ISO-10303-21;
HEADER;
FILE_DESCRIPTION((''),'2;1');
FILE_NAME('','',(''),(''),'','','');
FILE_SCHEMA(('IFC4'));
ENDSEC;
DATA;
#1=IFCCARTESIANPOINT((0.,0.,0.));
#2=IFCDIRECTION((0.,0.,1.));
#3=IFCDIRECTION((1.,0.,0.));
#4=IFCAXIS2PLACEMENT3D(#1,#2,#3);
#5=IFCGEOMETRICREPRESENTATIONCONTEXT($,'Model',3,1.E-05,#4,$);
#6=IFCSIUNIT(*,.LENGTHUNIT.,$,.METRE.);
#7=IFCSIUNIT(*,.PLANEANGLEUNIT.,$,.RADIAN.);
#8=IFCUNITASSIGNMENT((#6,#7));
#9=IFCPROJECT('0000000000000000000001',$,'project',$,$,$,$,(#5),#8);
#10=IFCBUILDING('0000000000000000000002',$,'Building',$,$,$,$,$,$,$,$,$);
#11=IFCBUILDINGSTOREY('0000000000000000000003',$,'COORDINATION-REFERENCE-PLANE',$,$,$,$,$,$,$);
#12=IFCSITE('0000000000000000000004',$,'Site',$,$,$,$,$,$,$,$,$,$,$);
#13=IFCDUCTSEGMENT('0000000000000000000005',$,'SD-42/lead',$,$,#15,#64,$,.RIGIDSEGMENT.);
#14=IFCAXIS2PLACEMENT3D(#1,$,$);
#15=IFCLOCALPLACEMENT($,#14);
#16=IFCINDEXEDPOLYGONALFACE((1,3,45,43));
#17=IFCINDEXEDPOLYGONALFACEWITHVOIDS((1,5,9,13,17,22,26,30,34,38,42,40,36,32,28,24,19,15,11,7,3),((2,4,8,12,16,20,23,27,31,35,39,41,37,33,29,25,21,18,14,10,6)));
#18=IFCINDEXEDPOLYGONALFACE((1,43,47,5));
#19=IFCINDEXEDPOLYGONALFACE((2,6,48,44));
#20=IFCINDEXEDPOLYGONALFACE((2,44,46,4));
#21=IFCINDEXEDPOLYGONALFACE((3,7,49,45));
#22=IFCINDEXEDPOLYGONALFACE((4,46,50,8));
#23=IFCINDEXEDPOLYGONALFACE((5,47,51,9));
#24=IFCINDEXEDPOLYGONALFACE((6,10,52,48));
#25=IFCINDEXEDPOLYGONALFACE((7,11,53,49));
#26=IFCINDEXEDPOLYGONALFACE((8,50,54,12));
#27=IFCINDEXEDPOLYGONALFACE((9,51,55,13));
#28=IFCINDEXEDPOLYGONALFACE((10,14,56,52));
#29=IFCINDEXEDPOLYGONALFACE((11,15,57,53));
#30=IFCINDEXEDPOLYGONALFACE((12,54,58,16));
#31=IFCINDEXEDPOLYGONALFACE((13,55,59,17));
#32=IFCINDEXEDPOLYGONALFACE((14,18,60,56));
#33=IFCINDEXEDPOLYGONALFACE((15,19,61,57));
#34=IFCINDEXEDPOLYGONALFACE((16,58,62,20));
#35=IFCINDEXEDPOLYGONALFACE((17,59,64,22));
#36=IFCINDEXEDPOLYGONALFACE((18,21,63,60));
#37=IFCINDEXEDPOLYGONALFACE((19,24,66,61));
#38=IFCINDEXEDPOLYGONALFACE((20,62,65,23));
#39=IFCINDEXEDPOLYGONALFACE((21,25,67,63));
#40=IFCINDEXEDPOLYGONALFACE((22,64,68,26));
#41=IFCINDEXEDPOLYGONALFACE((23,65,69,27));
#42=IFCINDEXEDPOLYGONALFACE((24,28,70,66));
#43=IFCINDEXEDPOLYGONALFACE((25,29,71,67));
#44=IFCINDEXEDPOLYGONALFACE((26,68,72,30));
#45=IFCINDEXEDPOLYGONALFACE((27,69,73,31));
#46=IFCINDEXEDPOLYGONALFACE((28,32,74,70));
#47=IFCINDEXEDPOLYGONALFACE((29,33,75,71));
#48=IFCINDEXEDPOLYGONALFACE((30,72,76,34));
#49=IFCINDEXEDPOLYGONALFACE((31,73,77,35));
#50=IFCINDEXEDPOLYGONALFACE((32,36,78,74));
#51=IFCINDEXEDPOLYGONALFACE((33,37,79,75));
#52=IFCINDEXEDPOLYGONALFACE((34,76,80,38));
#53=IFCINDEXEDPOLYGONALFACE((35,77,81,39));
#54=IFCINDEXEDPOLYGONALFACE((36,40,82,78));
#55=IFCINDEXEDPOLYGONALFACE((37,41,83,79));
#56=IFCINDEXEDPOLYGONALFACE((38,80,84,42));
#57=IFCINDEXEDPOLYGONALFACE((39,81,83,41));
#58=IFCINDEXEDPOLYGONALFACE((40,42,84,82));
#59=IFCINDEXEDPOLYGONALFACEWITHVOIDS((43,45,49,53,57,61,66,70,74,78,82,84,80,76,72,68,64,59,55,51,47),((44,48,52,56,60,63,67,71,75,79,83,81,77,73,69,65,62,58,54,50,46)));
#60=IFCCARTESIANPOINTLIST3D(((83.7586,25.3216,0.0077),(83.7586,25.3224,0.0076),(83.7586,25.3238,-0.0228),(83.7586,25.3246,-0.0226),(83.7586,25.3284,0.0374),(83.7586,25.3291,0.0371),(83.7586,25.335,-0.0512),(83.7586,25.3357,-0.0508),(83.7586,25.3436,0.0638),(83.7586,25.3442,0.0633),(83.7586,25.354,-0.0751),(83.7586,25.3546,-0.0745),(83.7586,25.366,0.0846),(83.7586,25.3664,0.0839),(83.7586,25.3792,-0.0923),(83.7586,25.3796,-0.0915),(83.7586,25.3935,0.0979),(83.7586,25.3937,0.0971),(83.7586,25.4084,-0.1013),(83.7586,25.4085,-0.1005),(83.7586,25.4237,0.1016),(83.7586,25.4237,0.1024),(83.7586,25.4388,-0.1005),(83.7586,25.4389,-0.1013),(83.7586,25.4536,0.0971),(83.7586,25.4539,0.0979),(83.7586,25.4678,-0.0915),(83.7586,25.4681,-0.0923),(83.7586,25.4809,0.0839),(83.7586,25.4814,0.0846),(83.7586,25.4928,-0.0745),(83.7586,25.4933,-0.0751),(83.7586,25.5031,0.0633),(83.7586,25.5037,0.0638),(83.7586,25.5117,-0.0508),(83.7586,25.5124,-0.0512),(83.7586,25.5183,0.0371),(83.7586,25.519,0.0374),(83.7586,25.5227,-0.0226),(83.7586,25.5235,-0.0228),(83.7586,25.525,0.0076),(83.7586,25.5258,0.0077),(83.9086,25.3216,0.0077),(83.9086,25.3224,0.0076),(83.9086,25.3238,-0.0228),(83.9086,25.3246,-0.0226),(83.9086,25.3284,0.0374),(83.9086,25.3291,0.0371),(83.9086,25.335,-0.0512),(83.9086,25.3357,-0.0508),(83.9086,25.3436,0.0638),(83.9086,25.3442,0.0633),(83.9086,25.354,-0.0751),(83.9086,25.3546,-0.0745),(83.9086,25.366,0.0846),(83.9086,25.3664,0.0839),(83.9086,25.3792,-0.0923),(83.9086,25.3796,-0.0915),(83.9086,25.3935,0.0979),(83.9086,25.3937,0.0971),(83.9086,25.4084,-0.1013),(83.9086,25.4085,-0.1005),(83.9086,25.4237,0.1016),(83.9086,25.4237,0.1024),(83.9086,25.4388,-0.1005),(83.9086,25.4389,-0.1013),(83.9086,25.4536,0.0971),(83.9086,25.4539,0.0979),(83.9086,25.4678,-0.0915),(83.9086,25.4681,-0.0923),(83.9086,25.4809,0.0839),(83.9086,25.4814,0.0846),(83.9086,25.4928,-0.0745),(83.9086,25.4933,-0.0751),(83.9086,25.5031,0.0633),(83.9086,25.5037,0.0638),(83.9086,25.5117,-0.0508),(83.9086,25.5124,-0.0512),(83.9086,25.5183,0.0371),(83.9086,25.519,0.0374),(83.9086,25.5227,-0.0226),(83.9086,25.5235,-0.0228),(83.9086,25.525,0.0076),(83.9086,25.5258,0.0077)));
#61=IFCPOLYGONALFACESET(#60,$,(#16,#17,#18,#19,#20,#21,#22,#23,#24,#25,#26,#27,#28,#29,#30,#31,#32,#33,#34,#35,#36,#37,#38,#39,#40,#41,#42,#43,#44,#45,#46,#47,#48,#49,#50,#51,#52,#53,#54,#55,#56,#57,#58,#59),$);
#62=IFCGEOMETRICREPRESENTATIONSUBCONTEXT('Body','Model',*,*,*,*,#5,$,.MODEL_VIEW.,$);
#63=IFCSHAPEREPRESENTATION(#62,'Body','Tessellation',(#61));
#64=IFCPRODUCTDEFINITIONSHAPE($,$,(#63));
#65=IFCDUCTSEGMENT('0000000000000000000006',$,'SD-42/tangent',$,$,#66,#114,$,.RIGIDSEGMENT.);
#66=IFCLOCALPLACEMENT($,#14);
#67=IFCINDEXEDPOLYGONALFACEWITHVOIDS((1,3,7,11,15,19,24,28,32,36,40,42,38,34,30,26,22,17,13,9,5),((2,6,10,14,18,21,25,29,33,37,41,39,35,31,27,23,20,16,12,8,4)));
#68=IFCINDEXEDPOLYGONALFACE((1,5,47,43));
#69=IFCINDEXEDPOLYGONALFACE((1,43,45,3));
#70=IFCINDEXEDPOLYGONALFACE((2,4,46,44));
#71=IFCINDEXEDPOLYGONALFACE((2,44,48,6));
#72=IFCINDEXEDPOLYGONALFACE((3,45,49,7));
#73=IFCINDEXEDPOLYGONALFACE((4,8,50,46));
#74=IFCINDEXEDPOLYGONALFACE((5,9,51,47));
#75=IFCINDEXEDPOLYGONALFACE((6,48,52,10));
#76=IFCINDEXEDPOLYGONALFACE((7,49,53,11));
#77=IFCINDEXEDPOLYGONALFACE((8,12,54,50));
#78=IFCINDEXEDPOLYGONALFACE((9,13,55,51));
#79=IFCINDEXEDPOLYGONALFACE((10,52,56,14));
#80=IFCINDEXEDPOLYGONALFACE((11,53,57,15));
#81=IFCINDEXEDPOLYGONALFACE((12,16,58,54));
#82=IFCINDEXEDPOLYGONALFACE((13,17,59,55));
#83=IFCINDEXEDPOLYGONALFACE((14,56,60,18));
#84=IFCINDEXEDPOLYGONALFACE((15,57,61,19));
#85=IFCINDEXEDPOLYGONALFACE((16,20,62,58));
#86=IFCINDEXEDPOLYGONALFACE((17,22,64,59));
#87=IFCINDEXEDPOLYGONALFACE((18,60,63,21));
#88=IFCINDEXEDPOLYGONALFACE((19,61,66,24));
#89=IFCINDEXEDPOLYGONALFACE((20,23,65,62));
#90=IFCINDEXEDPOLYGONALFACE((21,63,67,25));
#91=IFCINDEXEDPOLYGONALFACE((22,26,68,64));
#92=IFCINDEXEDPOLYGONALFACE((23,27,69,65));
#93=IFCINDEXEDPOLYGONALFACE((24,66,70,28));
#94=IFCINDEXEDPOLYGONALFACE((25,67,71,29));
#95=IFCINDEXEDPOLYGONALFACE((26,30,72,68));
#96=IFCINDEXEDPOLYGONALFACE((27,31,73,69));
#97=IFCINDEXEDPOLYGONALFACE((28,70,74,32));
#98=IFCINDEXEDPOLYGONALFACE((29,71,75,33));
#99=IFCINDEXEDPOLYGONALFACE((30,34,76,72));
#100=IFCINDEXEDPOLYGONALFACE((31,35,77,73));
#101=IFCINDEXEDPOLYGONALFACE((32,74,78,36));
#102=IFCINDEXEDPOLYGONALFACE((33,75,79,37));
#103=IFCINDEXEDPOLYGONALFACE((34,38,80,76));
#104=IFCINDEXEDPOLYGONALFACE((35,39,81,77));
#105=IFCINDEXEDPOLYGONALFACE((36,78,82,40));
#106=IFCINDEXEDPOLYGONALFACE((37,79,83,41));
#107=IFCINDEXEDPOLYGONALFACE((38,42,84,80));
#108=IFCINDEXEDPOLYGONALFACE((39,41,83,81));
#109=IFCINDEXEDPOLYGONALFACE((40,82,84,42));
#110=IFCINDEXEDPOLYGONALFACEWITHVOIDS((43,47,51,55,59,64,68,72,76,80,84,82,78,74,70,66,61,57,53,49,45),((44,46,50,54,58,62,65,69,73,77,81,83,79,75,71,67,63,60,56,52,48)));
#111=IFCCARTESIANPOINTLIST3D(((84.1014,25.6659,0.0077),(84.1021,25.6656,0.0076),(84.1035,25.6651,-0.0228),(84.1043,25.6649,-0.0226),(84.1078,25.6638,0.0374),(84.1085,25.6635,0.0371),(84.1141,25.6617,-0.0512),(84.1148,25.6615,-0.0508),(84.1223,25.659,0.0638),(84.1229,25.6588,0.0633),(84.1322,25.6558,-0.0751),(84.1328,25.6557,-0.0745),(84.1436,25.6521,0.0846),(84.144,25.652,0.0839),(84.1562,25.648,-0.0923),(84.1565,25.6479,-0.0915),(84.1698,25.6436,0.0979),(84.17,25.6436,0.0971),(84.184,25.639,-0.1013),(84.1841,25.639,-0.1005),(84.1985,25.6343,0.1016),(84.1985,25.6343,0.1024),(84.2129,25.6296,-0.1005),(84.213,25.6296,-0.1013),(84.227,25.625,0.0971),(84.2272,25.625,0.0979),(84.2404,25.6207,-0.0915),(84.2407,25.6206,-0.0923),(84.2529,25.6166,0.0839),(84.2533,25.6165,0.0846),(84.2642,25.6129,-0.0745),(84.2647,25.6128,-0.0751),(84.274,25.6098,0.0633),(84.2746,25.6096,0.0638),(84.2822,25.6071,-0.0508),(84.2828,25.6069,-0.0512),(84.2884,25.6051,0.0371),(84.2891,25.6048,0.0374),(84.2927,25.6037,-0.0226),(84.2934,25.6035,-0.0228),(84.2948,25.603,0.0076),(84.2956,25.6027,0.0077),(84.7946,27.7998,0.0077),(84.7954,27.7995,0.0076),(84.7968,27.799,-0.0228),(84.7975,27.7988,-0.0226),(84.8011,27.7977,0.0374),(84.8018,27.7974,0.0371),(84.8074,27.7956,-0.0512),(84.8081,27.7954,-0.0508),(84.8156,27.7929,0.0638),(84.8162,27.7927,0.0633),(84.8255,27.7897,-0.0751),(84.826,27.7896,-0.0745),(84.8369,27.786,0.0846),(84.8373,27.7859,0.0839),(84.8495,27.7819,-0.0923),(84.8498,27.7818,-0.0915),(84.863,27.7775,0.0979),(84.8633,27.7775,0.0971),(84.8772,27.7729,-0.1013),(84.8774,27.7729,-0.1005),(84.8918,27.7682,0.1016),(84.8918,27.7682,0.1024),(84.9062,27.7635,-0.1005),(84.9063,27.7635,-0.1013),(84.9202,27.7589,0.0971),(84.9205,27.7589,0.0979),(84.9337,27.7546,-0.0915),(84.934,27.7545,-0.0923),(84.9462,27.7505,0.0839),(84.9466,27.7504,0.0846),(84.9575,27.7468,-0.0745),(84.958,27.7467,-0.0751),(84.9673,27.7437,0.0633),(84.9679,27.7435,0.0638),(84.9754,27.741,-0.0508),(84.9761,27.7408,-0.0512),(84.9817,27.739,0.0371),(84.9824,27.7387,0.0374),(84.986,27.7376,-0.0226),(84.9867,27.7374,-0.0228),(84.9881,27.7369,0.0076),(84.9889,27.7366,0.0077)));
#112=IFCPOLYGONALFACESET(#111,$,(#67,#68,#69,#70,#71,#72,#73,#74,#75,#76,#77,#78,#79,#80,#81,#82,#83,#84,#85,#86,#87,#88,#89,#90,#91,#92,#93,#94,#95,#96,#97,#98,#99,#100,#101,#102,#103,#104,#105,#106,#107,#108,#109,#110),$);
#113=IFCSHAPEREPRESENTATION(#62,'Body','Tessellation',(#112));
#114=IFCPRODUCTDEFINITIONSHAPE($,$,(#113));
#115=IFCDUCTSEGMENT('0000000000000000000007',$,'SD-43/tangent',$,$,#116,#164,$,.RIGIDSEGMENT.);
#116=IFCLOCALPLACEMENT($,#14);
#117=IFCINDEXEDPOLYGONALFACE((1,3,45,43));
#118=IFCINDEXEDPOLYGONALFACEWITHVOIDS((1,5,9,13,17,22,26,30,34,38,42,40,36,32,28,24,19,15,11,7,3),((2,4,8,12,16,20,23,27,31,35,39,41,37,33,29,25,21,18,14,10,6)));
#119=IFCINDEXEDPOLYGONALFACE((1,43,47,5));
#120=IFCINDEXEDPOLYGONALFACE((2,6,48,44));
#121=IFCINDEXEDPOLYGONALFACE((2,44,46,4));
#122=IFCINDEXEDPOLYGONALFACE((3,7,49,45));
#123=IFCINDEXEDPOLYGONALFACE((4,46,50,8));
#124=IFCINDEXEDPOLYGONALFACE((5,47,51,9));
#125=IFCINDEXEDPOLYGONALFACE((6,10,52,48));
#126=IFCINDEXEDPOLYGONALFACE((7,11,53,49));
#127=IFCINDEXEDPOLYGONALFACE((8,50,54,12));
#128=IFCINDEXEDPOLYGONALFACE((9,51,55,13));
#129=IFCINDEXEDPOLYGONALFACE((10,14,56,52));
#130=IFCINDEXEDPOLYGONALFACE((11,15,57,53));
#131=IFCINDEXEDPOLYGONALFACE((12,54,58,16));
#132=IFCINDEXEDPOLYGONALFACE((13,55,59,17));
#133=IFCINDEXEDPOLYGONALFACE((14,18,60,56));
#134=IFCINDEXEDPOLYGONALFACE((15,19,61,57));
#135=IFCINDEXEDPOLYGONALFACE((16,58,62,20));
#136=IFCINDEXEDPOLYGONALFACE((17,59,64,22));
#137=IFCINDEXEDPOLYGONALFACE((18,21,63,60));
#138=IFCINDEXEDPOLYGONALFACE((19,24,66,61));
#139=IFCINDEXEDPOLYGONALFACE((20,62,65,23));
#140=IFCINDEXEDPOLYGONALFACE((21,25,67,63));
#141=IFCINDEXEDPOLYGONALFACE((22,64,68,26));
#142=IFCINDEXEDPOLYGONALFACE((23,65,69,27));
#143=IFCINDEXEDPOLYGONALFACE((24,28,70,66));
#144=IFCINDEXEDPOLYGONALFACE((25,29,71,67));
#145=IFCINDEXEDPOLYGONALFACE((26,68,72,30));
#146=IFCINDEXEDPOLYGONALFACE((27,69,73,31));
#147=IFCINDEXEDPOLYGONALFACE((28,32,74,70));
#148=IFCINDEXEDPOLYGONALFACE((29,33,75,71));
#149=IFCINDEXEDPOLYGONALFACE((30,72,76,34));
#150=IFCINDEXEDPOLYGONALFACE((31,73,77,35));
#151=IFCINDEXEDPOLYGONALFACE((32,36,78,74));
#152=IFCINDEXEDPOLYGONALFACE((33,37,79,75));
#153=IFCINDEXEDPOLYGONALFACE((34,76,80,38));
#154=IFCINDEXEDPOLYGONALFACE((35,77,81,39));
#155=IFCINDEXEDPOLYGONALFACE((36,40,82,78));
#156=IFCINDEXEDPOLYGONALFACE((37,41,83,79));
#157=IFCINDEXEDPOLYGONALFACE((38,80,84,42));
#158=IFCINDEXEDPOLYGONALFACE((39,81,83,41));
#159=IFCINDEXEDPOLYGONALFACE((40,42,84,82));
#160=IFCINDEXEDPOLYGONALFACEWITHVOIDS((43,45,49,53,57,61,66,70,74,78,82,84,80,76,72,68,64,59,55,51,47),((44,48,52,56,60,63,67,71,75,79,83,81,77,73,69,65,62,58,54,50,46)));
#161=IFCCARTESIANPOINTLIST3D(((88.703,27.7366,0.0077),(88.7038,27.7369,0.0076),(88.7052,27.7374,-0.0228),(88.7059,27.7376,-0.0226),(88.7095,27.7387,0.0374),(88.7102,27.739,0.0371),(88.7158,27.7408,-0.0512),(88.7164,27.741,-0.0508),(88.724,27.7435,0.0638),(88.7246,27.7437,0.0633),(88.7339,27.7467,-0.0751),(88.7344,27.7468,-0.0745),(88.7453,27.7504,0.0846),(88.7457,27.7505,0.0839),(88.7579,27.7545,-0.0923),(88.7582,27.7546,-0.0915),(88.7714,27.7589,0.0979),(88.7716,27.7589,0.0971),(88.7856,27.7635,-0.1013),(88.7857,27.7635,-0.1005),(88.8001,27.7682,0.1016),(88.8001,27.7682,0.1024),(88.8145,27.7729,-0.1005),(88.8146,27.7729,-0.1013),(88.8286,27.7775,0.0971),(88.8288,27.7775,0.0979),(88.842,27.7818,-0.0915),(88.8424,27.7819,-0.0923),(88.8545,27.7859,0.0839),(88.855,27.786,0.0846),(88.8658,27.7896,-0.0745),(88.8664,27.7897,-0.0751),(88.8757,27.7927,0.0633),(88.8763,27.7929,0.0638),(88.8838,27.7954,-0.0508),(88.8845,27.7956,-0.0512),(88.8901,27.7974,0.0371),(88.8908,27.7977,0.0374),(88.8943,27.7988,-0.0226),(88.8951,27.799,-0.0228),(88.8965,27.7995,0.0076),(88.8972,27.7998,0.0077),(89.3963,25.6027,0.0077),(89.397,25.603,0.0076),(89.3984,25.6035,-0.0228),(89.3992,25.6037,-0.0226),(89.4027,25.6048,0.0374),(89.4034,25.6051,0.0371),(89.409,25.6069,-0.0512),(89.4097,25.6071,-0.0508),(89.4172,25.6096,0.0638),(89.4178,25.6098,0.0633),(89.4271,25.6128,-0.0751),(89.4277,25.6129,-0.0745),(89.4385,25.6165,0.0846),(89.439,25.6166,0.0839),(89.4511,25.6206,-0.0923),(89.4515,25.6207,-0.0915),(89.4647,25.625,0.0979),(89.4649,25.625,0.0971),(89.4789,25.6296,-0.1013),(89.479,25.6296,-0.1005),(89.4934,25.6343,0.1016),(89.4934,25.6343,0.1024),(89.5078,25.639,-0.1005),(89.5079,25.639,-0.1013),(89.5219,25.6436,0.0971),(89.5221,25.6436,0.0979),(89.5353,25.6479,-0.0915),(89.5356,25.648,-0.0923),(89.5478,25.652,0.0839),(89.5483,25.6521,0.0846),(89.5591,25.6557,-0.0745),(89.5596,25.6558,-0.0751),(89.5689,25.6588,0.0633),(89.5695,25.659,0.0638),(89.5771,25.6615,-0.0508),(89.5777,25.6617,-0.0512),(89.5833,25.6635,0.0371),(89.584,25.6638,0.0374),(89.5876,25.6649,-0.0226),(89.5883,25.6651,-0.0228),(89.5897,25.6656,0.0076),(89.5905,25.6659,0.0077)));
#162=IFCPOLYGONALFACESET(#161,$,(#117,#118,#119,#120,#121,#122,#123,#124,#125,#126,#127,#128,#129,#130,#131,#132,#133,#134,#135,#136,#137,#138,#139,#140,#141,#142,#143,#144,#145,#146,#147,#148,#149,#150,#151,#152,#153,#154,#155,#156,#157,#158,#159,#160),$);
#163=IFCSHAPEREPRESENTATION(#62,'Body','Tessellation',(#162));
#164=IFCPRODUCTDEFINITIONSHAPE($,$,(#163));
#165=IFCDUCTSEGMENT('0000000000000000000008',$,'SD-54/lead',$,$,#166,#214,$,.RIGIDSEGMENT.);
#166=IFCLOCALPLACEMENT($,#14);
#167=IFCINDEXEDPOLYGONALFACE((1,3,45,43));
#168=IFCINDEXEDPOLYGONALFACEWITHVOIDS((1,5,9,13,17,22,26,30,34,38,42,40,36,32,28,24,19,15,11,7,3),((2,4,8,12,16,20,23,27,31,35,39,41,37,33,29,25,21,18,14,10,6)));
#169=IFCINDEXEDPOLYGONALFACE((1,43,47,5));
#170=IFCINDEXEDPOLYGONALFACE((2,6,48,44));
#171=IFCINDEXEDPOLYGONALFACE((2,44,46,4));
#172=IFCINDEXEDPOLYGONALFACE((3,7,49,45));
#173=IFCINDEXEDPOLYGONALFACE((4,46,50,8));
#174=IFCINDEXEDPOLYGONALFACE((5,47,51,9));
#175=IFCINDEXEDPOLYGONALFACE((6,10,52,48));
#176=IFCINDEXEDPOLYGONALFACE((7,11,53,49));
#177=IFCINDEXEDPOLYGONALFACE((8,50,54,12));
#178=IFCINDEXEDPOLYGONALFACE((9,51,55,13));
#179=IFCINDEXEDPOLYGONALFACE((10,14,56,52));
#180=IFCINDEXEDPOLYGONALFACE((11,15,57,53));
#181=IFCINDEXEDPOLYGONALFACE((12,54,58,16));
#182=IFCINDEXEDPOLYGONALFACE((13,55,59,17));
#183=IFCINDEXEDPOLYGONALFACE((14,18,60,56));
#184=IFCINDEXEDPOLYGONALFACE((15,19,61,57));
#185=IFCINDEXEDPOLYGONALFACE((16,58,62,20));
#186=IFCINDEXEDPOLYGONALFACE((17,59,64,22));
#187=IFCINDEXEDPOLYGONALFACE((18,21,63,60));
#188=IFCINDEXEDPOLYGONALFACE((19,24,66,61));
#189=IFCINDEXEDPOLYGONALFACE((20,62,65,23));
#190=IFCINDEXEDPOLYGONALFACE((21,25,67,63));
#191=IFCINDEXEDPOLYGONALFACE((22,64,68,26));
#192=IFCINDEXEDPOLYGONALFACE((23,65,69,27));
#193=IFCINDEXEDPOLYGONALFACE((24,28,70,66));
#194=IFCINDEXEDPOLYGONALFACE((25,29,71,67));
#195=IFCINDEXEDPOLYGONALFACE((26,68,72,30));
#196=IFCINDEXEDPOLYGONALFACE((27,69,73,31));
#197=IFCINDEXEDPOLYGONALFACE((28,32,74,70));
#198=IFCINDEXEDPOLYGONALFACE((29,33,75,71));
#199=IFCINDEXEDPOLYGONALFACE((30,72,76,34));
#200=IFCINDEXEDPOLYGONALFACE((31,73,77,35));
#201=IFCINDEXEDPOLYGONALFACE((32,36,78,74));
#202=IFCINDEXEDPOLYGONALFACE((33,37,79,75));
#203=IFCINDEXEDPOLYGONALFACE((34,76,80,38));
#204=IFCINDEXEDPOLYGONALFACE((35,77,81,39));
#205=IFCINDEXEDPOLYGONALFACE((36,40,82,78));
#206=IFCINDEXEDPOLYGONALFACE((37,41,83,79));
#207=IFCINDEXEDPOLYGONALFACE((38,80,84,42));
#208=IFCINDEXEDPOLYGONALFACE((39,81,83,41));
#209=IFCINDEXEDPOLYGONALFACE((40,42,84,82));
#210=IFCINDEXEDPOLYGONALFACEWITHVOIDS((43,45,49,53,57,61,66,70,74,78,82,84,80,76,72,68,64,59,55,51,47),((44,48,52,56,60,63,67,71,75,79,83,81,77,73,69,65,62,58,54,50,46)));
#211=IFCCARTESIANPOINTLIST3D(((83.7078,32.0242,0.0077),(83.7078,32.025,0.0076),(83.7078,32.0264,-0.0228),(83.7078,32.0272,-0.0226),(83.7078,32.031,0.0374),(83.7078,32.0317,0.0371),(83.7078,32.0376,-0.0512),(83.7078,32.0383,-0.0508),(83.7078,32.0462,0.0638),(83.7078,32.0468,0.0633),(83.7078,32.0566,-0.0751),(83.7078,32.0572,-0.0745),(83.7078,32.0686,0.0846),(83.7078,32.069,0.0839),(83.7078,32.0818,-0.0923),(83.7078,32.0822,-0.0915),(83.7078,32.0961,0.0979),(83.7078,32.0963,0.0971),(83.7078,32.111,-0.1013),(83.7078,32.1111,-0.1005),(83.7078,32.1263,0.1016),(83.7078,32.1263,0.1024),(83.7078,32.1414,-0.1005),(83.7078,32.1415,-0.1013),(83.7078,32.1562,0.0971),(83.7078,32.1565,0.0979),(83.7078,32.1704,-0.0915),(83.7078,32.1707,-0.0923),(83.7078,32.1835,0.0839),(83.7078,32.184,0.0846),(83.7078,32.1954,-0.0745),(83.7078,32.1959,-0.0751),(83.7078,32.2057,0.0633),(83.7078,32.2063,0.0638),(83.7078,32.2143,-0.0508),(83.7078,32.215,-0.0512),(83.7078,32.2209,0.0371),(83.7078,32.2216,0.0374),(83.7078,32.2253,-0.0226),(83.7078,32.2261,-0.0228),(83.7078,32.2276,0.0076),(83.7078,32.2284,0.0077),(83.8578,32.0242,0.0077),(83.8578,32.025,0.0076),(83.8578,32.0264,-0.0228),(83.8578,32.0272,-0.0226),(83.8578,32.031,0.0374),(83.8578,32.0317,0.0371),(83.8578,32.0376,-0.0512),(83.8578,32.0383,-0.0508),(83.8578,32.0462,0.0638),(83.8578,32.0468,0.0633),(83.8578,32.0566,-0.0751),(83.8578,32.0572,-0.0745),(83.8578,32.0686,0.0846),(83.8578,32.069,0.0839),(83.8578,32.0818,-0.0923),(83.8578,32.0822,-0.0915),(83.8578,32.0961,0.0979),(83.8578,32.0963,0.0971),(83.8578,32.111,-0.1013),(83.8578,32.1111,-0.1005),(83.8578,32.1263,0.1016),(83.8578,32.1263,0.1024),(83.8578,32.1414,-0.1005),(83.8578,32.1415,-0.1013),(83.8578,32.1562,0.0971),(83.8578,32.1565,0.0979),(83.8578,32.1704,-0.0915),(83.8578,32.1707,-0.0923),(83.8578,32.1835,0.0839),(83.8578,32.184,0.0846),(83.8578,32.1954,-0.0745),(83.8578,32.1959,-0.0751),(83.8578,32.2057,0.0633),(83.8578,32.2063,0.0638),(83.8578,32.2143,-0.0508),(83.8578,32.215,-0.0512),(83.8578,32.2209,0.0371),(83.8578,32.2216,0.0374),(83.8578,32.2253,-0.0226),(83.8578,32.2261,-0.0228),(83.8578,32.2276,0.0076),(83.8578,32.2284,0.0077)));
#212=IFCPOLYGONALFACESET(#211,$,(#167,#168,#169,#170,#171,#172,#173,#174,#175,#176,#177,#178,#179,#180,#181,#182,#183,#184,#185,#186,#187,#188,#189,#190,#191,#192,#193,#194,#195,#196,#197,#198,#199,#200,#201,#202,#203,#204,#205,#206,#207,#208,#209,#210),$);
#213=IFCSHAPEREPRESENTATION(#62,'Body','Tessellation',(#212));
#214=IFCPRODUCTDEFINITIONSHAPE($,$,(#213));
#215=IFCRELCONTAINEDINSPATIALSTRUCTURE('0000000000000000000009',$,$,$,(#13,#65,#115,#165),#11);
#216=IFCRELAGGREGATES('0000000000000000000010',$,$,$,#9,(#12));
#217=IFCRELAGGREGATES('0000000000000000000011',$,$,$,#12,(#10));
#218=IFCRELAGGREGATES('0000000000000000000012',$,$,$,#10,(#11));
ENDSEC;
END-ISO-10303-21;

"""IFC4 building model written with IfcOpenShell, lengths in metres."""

from ifc_helpers import new_model, si_unit, frame, origin_with_axes, place, context, subcontext, project, spatial, hollow_circle, extrude, element, save


model = new_model("IFC4")

# Units and contexts
model_context = context("Model", 3, precision=1e-05, world=origin_with_axes())
body_context_1 = subcontext(model_context, "Body", "Model", "MODEL_VIEW")
ifc_project = project(units=[si_unit("LENGTHUNIT", "METRE"), si_unit("PLANEANGLEUNIT", "RADIAN")], contexts=[model_context])

# Site, building, storey
site = spatial("IfcSite", under=ifc_project, Name="Site")
building = spatial("IfcBuilding", under=site, Name="Building")
storey = spatial("IfcBuildingStorey", under=building, Name="COORDINATION-REFERENCE-PLANE")

# Duct segment
duct_segment_1_placement = place(None, frame((83.7586, 25.4237, 0.0), z_axis=(1.0, 0.0, 0.0), x_axis=(0.0, 0.0, 1.0)))
element("IfcDuctSegment", 1, at=duct_segment_1_placement, inside=storey, Name="SD-42/lead", PredefinedType="RIGIDSEGMENT", context=body_context_1, shape_type="SweptSolid", body=[
    extrude(hollow_circle(Radius=0.1024, WallThickness=0.0008), origin_with_axes(), (0.0, 0.0, 1.0), 0.15),
])

# Duct segment
duct_segment_2_placement = place(None, frame((84.1985, 25.6343, 0.0), z_axis=(0.30899, 0.951065, 0.0), x_axis=(0.0, 0.0, 1.0)))
element("IfcDuctSegment", 2, at=duct_segment_2_placement, inside=storey, Name="SD-42/tangent", PredefinedType="RIGIDSEGMENT", context=body_context_1, shape_type="SweptSolid", body=[
    extrude(hollow_circle(Radius=0.1024, WallThickness=0.0008), origin_with_axes(), (0.0, 0.0, 1.0), 2.2437),
])

# Duct segment
duct_segment_3_placement = place(None, frame((89.4934, 25.6343, 0.0), z_axis=(-0.30899, 0.951065, 0.0), x_axis=(0.0, 0.0, 1.0)))
element("IfcDuctSegment", 3, at=duct_segment_3_placement, inside=storey, Name="SD-43/tangent", PredefinedType="RIGIDSEGMENT", context=body_context_1, shape_type="SweptSolid", body=[
    extrude(hollow_circle(Radius=0.1024, WallThickness=0.0008), origin_with_axes(), (0.0, 0.0, 1.0), 2.2437),
])

# Duct segment
duct_segment_4_placement = place(None, frame((83.7078, 32.1263, 0.0), z_axis=(1.0, 0.0, 0.0), x_axis=(0.0, 0.0, 1.0)))
element("IfcDuctSegment", 4, at=duct_segment_4_placement, inside=storey, Name="SD-54/lead", PredefinedType="RIGIDSEGMENT", context=body_context_1, shape_type="SweptSolid", body=[
    extrude(hollow_circle(Radius=0.1024, WallThickness=0.0008), origin_with_axes(), (0.0, 0.0, 1.0), 0.15),
])

save(model, "model.ifc")
